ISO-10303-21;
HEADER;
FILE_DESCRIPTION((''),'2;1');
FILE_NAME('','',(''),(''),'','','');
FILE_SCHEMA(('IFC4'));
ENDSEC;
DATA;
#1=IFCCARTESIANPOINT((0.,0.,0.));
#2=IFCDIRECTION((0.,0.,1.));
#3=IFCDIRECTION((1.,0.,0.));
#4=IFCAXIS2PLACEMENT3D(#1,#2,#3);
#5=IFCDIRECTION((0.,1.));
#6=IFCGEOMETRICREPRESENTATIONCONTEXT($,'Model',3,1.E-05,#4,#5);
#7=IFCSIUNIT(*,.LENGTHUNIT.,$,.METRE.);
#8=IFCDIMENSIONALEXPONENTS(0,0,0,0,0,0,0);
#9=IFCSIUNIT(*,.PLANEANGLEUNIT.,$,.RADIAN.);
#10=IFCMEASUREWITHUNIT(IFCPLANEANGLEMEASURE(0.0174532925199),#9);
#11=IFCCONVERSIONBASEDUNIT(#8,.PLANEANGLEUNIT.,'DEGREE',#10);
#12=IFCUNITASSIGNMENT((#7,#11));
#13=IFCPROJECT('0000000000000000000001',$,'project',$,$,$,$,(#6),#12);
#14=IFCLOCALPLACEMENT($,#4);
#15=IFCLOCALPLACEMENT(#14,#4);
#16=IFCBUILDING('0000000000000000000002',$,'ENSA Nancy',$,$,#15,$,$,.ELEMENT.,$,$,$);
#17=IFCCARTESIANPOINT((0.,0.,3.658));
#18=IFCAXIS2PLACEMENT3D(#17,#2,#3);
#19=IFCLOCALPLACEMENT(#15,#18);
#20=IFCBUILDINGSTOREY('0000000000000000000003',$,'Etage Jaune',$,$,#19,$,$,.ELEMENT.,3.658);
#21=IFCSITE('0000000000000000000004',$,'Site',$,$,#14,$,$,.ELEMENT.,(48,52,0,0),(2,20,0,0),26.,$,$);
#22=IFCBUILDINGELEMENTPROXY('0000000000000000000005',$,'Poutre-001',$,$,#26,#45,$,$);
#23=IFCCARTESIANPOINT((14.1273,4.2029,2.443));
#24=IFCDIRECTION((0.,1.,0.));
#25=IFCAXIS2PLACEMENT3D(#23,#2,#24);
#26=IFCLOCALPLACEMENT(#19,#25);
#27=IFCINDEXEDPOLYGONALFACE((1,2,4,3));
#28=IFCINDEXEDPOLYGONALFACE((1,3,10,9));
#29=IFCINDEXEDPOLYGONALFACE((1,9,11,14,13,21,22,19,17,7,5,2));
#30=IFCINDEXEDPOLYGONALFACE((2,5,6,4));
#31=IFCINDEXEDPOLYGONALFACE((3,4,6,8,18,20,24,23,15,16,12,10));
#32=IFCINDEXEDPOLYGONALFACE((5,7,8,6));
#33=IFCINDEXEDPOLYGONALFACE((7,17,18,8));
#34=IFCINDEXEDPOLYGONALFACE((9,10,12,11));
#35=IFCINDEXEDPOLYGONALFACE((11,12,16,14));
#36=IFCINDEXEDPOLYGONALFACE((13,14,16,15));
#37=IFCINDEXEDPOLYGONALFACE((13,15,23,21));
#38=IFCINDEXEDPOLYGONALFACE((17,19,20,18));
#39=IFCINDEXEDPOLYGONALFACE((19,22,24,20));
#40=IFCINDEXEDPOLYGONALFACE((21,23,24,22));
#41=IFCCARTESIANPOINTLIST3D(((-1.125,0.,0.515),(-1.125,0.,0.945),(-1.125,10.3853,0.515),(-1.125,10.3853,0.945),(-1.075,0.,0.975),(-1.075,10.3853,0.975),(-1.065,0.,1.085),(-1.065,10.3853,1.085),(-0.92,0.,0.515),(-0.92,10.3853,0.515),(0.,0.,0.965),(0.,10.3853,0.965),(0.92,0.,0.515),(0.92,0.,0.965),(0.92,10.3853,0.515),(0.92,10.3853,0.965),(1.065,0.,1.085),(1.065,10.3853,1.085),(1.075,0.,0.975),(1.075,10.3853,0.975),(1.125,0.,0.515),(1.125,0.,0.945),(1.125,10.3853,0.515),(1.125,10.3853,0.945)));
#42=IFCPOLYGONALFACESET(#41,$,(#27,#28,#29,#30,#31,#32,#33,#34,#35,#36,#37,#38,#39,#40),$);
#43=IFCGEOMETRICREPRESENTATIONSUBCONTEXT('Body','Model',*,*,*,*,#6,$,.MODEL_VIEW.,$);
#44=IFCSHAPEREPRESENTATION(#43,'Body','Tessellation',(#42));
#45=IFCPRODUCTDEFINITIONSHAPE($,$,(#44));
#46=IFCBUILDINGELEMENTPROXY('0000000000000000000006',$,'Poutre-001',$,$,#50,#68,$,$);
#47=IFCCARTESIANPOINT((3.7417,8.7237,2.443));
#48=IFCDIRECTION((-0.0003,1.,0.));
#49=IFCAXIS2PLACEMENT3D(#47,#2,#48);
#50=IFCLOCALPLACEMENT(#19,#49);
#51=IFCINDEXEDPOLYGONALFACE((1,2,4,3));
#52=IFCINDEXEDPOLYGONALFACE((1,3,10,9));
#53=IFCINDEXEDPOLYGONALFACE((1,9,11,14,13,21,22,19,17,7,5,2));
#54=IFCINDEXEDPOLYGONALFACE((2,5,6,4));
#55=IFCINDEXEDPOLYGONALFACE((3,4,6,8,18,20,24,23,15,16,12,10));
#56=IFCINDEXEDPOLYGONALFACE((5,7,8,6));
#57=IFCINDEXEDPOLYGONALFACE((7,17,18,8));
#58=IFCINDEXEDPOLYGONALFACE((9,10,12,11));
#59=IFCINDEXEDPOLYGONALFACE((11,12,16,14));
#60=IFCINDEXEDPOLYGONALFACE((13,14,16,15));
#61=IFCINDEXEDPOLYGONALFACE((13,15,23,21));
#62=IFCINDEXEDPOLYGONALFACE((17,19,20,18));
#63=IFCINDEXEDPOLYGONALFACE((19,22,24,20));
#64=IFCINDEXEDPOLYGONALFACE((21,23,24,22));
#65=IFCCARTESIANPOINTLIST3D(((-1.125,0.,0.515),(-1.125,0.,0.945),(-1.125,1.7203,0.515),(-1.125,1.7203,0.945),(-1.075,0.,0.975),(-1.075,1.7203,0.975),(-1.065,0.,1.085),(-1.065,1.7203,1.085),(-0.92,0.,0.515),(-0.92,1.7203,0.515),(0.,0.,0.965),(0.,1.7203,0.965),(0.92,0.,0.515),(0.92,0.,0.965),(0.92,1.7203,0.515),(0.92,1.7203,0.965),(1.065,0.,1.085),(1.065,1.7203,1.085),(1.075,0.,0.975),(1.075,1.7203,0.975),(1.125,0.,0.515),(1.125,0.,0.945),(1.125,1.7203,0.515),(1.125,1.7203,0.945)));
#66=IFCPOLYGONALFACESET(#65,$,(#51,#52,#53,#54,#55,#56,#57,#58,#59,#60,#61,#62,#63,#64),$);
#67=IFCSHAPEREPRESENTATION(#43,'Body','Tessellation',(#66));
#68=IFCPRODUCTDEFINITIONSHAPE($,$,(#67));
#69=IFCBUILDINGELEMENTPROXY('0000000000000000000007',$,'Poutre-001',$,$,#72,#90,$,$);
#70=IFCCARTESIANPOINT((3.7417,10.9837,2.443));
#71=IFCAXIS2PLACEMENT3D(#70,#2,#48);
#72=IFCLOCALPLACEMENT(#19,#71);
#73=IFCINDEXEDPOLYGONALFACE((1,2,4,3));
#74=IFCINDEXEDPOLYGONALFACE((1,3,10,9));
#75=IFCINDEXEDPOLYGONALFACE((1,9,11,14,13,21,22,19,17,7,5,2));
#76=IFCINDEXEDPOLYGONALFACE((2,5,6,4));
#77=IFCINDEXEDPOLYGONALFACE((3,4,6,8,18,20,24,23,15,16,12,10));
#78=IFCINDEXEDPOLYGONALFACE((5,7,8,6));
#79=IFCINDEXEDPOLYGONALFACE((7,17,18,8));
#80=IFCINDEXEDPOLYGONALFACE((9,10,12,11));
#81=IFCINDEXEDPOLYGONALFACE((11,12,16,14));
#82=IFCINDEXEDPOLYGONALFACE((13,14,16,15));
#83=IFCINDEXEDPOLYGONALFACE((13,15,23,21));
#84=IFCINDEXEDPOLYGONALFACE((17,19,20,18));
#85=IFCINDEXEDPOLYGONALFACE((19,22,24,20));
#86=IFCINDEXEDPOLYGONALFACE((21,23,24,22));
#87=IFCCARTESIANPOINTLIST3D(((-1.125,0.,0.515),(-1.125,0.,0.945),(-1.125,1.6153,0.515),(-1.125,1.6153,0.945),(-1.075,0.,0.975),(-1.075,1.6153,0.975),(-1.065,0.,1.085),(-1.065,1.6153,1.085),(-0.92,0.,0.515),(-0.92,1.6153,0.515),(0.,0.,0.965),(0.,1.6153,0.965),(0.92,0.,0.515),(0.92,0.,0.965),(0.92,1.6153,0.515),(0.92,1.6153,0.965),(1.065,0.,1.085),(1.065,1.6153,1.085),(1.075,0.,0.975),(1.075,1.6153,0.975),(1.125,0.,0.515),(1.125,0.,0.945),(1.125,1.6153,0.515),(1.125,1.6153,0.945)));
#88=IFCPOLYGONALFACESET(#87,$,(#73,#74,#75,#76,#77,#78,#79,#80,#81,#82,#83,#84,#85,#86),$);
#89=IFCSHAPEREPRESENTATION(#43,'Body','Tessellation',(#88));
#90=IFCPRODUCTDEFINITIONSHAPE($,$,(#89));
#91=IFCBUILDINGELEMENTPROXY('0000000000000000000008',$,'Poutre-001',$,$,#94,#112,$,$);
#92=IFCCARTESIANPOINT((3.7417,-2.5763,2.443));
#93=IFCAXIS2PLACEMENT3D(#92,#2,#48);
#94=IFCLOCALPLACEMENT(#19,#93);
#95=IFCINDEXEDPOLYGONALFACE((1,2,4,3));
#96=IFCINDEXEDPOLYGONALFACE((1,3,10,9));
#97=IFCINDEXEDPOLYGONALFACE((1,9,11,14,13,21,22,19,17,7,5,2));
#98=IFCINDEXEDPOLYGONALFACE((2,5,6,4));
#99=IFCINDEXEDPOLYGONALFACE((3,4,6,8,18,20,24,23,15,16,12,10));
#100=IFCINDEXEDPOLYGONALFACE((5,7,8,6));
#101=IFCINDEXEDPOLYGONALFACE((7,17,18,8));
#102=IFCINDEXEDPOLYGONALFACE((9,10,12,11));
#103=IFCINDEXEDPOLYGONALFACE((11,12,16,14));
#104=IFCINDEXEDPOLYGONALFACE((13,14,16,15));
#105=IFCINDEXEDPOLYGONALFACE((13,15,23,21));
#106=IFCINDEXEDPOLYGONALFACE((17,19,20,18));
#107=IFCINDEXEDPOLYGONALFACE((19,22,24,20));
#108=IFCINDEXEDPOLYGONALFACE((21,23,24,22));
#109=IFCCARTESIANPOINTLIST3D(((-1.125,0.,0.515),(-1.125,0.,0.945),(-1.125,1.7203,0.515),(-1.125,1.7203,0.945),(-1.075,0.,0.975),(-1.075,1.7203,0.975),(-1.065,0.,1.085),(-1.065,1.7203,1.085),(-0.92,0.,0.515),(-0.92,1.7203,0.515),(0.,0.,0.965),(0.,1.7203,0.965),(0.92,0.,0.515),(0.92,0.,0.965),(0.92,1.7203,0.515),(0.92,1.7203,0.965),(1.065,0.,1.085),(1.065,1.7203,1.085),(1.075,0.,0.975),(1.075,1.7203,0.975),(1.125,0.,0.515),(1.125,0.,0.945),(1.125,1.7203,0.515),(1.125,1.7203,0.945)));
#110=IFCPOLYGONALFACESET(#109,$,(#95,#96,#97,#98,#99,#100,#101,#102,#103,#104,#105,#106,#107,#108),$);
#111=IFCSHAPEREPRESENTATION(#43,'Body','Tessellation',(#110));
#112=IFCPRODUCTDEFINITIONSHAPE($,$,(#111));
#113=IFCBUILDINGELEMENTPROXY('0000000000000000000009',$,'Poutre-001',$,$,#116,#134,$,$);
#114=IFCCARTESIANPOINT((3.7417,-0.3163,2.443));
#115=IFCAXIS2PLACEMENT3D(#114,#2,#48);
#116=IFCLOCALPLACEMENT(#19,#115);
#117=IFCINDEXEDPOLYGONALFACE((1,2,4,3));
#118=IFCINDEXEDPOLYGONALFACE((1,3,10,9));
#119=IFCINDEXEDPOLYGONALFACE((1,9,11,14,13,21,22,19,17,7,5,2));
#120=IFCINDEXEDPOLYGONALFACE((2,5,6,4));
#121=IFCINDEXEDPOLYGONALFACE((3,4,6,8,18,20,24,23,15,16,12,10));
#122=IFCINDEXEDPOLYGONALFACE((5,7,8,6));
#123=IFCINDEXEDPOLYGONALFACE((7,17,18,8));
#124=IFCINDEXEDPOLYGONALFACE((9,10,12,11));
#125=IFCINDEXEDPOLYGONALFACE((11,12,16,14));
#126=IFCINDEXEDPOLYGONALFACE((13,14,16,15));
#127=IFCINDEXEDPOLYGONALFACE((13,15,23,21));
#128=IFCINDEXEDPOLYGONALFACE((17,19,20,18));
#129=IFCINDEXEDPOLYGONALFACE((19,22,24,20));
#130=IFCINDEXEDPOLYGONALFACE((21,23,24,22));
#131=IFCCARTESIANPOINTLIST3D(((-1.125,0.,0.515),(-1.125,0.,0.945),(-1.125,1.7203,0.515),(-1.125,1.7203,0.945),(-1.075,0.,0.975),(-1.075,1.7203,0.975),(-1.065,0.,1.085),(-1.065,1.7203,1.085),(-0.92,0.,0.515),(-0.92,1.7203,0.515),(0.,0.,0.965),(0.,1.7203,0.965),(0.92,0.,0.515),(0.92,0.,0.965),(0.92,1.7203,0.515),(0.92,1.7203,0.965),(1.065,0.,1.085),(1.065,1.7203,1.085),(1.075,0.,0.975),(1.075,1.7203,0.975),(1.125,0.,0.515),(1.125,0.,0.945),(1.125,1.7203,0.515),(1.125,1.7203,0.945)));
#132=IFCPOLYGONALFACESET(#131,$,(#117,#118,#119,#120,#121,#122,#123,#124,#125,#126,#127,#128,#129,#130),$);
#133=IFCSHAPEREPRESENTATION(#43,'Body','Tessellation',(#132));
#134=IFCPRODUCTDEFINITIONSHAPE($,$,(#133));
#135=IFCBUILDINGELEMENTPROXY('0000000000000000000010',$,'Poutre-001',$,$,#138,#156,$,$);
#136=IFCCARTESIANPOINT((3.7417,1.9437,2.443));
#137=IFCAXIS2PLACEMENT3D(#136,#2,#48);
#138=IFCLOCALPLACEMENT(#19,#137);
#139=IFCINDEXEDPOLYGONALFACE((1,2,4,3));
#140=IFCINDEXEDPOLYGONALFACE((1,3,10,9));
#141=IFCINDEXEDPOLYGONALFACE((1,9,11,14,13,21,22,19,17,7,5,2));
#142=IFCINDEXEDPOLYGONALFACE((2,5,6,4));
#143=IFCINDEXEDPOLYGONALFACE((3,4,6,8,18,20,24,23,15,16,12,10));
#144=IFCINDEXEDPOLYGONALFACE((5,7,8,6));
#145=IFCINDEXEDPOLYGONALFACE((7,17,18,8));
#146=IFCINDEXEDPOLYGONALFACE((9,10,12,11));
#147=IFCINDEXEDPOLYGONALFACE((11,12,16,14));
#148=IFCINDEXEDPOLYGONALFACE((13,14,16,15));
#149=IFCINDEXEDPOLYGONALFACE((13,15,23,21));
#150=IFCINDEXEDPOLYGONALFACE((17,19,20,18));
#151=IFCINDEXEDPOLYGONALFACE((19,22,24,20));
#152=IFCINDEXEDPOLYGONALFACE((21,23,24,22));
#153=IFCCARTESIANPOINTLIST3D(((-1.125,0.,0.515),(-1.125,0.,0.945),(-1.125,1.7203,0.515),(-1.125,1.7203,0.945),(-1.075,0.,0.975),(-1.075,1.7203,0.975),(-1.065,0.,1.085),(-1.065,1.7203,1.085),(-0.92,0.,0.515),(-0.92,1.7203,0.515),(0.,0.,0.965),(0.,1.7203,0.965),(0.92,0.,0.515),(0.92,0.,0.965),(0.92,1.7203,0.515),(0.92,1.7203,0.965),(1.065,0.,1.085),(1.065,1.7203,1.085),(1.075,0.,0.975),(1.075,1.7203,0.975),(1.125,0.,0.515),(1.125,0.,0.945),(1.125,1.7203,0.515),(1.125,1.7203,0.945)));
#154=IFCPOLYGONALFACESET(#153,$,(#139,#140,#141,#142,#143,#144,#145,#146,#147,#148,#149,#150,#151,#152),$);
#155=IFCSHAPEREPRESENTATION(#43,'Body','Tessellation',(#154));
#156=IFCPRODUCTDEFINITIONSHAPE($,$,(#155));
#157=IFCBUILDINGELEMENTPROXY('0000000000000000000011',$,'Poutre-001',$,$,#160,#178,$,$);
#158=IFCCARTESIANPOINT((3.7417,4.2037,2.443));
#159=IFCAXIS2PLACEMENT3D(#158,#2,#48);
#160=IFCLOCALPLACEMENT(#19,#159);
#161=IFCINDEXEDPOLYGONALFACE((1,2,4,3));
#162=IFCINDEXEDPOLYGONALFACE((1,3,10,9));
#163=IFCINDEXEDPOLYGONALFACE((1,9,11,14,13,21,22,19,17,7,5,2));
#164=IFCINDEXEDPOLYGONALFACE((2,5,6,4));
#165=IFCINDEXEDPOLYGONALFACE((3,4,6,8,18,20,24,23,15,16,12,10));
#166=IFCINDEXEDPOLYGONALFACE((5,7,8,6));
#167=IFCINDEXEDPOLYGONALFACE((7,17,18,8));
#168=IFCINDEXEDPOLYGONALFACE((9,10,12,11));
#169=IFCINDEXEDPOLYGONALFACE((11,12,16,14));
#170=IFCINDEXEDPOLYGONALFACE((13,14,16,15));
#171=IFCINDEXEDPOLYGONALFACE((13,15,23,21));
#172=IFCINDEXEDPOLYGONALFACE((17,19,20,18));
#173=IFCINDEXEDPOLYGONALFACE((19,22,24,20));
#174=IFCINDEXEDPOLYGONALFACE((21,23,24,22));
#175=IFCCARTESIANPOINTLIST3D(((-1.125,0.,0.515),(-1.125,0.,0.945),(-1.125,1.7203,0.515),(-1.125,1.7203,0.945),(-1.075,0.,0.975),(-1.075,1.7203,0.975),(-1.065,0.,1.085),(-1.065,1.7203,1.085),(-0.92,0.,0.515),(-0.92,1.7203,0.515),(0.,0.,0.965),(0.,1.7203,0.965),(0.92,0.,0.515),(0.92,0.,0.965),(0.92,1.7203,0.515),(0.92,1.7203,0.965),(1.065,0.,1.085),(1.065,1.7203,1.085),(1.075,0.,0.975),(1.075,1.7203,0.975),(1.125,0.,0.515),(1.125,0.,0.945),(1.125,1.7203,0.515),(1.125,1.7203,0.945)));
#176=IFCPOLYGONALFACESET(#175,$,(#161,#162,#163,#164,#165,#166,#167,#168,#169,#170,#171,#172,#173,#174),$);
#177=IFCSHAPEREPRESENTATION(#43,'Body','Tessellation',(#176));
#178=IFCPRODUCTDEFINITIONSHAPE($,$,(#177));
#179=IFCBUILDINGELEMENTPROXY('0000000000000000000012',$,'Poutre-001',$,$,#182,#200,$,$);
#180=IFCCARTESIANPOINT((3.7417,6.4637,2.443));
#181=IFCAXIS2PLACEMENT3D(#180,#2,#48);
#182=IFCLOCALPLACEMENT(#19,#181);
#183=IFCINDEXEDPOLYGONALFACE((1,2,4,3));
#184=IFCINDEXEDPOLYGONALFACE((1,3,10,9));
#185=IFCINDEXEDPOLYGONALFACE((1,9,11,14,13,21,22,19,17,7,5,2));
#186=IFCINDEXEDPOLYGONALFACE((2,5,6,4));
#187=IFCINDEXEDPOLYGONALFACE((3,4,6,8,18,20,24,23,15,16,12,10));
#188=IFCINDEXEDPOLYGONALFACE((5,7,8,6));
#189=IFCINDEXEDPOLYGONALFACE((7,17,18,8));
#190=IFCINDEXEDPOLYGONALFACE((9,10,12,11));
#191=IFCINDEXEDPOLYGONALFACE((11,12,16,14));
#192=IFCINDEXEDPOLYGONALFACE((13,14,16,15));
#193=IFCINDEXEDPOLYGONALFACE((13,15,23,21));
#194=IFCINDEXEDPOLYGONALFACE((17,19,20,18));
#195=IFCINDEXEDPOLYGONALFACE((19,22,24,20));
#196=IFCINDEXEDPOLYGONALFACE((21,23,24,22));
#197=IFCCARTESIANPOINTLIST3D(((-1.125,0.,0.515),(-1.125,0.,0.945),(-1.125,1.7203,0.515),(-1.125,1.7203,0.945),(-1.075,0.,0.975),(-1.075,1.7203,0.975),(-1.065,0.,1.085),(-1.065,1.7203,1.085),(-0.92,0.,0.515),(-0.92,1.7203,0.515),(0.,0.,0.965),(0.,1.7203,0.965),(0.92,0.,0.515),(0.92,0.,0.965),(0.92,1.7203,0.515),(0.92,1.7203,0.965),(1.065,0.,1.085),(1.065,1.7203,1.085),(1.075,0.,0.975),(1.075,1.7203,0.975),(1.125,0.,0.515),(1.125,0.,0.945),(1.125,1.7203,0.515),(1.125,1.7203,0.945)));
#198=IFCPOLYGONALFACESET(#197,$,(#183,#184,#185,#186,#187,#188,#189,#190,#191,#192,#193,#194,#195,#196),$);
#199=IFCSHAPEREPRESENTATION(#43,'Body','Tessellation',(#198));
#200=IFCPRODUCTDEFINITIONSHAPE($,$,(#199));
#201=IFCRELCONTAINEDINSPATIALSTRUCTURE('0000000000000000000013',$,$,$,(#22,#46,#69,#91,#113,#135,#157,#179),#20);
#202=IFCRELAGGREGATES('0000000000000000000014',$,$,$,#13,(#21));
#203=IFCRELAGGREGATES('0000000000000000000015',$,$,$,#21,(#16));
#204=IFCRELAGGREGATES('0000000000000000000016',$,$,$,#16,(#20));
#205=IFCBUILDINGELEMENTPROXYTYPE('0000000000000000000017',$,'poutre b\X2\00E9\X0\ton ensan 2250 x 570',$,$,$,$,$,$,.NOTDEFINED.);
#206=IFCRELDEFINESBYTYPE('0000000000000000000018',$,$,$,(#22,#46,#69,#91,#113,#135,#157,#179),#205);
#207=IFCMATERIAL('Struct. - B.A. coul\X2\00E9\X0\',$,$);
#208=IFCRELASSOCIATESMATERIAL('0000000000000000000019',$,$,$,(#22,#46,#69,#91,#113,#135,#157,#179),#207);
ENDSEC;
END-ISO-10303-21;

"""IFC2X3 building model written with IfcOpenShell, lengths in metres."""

from ifc_helpers import new_model, entity, si_unit, converted_unit, direction, frame, origin_with_axes, place, context, subcontext, project, spatial, polyline, outline, extrude, material, type_object, element, save


model = new_model("IFC2X3")

# Units and contexts
model_context = context("Model", 3, precision=1e-05, world=origin_with_axes(), true_north=direction((0.0, 1.0)))
body_context = subcontext(model_context, "Body", "Model", "MODEL_VIEW")
ifc_project = project(units=[si_unit("LENGTHUNIT", "METRE"), converted_unit("PLANEANGLEUNIT", "DEGREE", entity("IfcPlaneAngleMeasure", 0.0174532925199), si_unit("PLANEANGLEUNIT", "RADIAN"), dimensions=[0, 0, 0, 0, 0, 0, 0])], contexts=[model_context])

# Site, building, storey
site_placement = place(None, origin_with_axes())
site = spatial("IfcSite", under=ifc_project, at=site_placement, Name="Site", CompositionType="ELEMENT", RefLatitude=(48, 52, 0, 0), RefLongitude=(2, 20, 0, 0), RefElevation=26.0)
building_placement = place(site_placement, origin_with_axes())
building = spatial("IfcBuilding", under=site, at=building_placement, Name="ENSA Nancy", CompositionType="ELEMENT")
storey_placement = place(building_placement, frame((0.0, 0.0, 3.658), z_axis=(0.0, 0.0, 1.0), x_axis=(1.0, 0.0, 0.0)))
storey = spatial("IfcBuildingStorey", under=building, at=storey_placement, Name="Etage Jaune", CompositionType="ELEMENT", Elevation=3.658)

# Building element proxies
ifc_material_1 = material(Name="Struct. - B.A. coulé")
building_element_proxy_type_1 = type_object("IfcBuildingElementProxyType", Name="poutre béton ensan 2250 x 570", PredefinedType="NOTDEFINED")
proxy_1_placement = place(storey_placement, frame((14.1273, 4.2029, 2.443), z_axis=(0.0, 0.0, 1.0), x_axis=(0.0, 1.0, 0.0)))
element("IfcBuildingElementProxy", 1, at=proxy_1_placement, inside=storey, type_object=building_element_proxy_type_1, material=ifc_material_1, Name="Poutre-001", context=body_context, shape_type="SweptSolid", body=[
    extrude(outline(polyline([(-1.065, 1.085), (-1.075, 0.975), (-1.125, 0.945), (-1.125, 0.515), (-0.92, 0.515), (0.0, 0.965), (0.92, 0.965), (0.92, 0.515), (1.125, 0.515), (1.125, 0.945), (1.075, 0.975), (1.065, 1.085), (-1.065, 1.085)])), frame((0.0, 10.3853, 0.0), z_axis=(0.0, -1.0, 0.0), x_axis=(1.0, 0.0, 0.0)), (0.0, 0.0, 1.0), 10.3853),
])
proxy_2_placement = place(storey_placement, frame((3.7417, 8.7237, 2.443), z_axis=(0.0, 0.0, 1.0), x_axis=(-0.0003, 1.0, 0.0)))
element("IfcBuildingElementProxy", 2, at=proxy_2_placement, inside=storey, type_object=building_element_proxy_type_1, material=ifc_material_1, Name="Poutre-001", context=body_context, shape_type="SweptSolid", body=[
    extrude(outline(polyline([(-1.065, 1.085), (-1.075, 0.975), (-1.125, 0.945), (-1.125, 0.515), (-0.92, 0.515), (0.0, 0.965), (0.92, 0.965), (0.92, 0.515), (1.125, 0.515), (1.125, 0.945), (1.075, 0.975), (1.065, 1.085), (-1.065, 1.085)])), frame((0.0, 1.7203, 0.0), z_axis=(0.0, -1.0, 0.0), x_axis=(1.0, 0.0, 0.0)), (0.0, 0.0, 1.0), 1.7203),
])
proxy_3_placement = place(storey_placement, frame((3.7417, 10.9837, 2.443), z_axis=(0.0, 0.0, 1.0), x_axis=(-0.0003, 1.0, 0.0)))
element("IfcBuildingElementProxy", 3, at=proxy_3_placement, inside=storey, type_object=building_element_proxy_type_1, material=ifc_material_1, Name="Poutre-001", context=body_context, shape_type="SweptSolid", body=[
    extrude(outline(polyline([(-1.065, 1.085), (-1.075, 0.975), (-1.125, 0.945), (-1.125, 0.515), (-0.92, 0.515), (0.0, 0.965), (0.92, 0.965), (0.92, 0.515), (1.125, 0.515), (1.125, 0.945), (1.075, 0.975), (1.065, 1.085), (-1.065, 1.085)])), frame((0.0, 1.6153, 0.0), z_axis=(0.0, -1.0, 0.0), x_axis=(1.0, 0.0, 0.0)), (0.0, 0.0, 1.0), 1.6153),
])
for number, where, z_axis, x_axis, name in (
    (4, (3.7417, -2.5763, 2.443), (0.0, 0.0, 1.0), (-0.0003, 1.0, 0.0), "Poutre-001"),
    (5, (3.7417, -0.3163, 2.443), (0.0, 0.0, 1.0), (-0.0003, 1.0, 0.0), "Poutre-001"),
    (6, (3.7417, 1.9437, 2.443), (0.0, 0.0, 1.0), (-0.0003, 1.0, 0.0), "Poutre-001"),
    (7, (3.7417, 4.2037, 2.443), (0.0, 0.0, 1.0), (-0.0003, 1.0, 0.0), "Poutre-001"),
    (8, (3.7417, 6.4637, 2.443), (0.0, 0.0, 1.0), (-0.0003, 1.0, 0.0), "Poutre-001"),
):
    element("IfcBuildingElementProxy", number, at=place(storey_placement, frame(where, z_axis=z_axis, x_axis=x_axis)), inside=storey, type_object=building_element_proxy_type_1, material=ifc_material_1, Name=name, context=body_context, shape_type="SweptSolid", body=[
        extrude(outline(polyline([(-1.065, 1.085), (-1.075, 0.975), (-1.125, 0.945), (-1.125, 0.515), (-0.92, 0.515), (0.0, 0.965), (0.92, 0.965), (0.92, 0.515), (1.125, 0.515), (1.125, 0.945), (1.075, 0.975), (1.065, 1.085), (-1.065, 1.085)])), frame((0.0, 1.7203, 0.0), z_axis=(0.0, -1.0, 0.0), x_axis=(1.0, 0.0, 0.0)), (0.0, 0.0, 1.0), 1.7203),
    ])

save(model, "model.ifc")
